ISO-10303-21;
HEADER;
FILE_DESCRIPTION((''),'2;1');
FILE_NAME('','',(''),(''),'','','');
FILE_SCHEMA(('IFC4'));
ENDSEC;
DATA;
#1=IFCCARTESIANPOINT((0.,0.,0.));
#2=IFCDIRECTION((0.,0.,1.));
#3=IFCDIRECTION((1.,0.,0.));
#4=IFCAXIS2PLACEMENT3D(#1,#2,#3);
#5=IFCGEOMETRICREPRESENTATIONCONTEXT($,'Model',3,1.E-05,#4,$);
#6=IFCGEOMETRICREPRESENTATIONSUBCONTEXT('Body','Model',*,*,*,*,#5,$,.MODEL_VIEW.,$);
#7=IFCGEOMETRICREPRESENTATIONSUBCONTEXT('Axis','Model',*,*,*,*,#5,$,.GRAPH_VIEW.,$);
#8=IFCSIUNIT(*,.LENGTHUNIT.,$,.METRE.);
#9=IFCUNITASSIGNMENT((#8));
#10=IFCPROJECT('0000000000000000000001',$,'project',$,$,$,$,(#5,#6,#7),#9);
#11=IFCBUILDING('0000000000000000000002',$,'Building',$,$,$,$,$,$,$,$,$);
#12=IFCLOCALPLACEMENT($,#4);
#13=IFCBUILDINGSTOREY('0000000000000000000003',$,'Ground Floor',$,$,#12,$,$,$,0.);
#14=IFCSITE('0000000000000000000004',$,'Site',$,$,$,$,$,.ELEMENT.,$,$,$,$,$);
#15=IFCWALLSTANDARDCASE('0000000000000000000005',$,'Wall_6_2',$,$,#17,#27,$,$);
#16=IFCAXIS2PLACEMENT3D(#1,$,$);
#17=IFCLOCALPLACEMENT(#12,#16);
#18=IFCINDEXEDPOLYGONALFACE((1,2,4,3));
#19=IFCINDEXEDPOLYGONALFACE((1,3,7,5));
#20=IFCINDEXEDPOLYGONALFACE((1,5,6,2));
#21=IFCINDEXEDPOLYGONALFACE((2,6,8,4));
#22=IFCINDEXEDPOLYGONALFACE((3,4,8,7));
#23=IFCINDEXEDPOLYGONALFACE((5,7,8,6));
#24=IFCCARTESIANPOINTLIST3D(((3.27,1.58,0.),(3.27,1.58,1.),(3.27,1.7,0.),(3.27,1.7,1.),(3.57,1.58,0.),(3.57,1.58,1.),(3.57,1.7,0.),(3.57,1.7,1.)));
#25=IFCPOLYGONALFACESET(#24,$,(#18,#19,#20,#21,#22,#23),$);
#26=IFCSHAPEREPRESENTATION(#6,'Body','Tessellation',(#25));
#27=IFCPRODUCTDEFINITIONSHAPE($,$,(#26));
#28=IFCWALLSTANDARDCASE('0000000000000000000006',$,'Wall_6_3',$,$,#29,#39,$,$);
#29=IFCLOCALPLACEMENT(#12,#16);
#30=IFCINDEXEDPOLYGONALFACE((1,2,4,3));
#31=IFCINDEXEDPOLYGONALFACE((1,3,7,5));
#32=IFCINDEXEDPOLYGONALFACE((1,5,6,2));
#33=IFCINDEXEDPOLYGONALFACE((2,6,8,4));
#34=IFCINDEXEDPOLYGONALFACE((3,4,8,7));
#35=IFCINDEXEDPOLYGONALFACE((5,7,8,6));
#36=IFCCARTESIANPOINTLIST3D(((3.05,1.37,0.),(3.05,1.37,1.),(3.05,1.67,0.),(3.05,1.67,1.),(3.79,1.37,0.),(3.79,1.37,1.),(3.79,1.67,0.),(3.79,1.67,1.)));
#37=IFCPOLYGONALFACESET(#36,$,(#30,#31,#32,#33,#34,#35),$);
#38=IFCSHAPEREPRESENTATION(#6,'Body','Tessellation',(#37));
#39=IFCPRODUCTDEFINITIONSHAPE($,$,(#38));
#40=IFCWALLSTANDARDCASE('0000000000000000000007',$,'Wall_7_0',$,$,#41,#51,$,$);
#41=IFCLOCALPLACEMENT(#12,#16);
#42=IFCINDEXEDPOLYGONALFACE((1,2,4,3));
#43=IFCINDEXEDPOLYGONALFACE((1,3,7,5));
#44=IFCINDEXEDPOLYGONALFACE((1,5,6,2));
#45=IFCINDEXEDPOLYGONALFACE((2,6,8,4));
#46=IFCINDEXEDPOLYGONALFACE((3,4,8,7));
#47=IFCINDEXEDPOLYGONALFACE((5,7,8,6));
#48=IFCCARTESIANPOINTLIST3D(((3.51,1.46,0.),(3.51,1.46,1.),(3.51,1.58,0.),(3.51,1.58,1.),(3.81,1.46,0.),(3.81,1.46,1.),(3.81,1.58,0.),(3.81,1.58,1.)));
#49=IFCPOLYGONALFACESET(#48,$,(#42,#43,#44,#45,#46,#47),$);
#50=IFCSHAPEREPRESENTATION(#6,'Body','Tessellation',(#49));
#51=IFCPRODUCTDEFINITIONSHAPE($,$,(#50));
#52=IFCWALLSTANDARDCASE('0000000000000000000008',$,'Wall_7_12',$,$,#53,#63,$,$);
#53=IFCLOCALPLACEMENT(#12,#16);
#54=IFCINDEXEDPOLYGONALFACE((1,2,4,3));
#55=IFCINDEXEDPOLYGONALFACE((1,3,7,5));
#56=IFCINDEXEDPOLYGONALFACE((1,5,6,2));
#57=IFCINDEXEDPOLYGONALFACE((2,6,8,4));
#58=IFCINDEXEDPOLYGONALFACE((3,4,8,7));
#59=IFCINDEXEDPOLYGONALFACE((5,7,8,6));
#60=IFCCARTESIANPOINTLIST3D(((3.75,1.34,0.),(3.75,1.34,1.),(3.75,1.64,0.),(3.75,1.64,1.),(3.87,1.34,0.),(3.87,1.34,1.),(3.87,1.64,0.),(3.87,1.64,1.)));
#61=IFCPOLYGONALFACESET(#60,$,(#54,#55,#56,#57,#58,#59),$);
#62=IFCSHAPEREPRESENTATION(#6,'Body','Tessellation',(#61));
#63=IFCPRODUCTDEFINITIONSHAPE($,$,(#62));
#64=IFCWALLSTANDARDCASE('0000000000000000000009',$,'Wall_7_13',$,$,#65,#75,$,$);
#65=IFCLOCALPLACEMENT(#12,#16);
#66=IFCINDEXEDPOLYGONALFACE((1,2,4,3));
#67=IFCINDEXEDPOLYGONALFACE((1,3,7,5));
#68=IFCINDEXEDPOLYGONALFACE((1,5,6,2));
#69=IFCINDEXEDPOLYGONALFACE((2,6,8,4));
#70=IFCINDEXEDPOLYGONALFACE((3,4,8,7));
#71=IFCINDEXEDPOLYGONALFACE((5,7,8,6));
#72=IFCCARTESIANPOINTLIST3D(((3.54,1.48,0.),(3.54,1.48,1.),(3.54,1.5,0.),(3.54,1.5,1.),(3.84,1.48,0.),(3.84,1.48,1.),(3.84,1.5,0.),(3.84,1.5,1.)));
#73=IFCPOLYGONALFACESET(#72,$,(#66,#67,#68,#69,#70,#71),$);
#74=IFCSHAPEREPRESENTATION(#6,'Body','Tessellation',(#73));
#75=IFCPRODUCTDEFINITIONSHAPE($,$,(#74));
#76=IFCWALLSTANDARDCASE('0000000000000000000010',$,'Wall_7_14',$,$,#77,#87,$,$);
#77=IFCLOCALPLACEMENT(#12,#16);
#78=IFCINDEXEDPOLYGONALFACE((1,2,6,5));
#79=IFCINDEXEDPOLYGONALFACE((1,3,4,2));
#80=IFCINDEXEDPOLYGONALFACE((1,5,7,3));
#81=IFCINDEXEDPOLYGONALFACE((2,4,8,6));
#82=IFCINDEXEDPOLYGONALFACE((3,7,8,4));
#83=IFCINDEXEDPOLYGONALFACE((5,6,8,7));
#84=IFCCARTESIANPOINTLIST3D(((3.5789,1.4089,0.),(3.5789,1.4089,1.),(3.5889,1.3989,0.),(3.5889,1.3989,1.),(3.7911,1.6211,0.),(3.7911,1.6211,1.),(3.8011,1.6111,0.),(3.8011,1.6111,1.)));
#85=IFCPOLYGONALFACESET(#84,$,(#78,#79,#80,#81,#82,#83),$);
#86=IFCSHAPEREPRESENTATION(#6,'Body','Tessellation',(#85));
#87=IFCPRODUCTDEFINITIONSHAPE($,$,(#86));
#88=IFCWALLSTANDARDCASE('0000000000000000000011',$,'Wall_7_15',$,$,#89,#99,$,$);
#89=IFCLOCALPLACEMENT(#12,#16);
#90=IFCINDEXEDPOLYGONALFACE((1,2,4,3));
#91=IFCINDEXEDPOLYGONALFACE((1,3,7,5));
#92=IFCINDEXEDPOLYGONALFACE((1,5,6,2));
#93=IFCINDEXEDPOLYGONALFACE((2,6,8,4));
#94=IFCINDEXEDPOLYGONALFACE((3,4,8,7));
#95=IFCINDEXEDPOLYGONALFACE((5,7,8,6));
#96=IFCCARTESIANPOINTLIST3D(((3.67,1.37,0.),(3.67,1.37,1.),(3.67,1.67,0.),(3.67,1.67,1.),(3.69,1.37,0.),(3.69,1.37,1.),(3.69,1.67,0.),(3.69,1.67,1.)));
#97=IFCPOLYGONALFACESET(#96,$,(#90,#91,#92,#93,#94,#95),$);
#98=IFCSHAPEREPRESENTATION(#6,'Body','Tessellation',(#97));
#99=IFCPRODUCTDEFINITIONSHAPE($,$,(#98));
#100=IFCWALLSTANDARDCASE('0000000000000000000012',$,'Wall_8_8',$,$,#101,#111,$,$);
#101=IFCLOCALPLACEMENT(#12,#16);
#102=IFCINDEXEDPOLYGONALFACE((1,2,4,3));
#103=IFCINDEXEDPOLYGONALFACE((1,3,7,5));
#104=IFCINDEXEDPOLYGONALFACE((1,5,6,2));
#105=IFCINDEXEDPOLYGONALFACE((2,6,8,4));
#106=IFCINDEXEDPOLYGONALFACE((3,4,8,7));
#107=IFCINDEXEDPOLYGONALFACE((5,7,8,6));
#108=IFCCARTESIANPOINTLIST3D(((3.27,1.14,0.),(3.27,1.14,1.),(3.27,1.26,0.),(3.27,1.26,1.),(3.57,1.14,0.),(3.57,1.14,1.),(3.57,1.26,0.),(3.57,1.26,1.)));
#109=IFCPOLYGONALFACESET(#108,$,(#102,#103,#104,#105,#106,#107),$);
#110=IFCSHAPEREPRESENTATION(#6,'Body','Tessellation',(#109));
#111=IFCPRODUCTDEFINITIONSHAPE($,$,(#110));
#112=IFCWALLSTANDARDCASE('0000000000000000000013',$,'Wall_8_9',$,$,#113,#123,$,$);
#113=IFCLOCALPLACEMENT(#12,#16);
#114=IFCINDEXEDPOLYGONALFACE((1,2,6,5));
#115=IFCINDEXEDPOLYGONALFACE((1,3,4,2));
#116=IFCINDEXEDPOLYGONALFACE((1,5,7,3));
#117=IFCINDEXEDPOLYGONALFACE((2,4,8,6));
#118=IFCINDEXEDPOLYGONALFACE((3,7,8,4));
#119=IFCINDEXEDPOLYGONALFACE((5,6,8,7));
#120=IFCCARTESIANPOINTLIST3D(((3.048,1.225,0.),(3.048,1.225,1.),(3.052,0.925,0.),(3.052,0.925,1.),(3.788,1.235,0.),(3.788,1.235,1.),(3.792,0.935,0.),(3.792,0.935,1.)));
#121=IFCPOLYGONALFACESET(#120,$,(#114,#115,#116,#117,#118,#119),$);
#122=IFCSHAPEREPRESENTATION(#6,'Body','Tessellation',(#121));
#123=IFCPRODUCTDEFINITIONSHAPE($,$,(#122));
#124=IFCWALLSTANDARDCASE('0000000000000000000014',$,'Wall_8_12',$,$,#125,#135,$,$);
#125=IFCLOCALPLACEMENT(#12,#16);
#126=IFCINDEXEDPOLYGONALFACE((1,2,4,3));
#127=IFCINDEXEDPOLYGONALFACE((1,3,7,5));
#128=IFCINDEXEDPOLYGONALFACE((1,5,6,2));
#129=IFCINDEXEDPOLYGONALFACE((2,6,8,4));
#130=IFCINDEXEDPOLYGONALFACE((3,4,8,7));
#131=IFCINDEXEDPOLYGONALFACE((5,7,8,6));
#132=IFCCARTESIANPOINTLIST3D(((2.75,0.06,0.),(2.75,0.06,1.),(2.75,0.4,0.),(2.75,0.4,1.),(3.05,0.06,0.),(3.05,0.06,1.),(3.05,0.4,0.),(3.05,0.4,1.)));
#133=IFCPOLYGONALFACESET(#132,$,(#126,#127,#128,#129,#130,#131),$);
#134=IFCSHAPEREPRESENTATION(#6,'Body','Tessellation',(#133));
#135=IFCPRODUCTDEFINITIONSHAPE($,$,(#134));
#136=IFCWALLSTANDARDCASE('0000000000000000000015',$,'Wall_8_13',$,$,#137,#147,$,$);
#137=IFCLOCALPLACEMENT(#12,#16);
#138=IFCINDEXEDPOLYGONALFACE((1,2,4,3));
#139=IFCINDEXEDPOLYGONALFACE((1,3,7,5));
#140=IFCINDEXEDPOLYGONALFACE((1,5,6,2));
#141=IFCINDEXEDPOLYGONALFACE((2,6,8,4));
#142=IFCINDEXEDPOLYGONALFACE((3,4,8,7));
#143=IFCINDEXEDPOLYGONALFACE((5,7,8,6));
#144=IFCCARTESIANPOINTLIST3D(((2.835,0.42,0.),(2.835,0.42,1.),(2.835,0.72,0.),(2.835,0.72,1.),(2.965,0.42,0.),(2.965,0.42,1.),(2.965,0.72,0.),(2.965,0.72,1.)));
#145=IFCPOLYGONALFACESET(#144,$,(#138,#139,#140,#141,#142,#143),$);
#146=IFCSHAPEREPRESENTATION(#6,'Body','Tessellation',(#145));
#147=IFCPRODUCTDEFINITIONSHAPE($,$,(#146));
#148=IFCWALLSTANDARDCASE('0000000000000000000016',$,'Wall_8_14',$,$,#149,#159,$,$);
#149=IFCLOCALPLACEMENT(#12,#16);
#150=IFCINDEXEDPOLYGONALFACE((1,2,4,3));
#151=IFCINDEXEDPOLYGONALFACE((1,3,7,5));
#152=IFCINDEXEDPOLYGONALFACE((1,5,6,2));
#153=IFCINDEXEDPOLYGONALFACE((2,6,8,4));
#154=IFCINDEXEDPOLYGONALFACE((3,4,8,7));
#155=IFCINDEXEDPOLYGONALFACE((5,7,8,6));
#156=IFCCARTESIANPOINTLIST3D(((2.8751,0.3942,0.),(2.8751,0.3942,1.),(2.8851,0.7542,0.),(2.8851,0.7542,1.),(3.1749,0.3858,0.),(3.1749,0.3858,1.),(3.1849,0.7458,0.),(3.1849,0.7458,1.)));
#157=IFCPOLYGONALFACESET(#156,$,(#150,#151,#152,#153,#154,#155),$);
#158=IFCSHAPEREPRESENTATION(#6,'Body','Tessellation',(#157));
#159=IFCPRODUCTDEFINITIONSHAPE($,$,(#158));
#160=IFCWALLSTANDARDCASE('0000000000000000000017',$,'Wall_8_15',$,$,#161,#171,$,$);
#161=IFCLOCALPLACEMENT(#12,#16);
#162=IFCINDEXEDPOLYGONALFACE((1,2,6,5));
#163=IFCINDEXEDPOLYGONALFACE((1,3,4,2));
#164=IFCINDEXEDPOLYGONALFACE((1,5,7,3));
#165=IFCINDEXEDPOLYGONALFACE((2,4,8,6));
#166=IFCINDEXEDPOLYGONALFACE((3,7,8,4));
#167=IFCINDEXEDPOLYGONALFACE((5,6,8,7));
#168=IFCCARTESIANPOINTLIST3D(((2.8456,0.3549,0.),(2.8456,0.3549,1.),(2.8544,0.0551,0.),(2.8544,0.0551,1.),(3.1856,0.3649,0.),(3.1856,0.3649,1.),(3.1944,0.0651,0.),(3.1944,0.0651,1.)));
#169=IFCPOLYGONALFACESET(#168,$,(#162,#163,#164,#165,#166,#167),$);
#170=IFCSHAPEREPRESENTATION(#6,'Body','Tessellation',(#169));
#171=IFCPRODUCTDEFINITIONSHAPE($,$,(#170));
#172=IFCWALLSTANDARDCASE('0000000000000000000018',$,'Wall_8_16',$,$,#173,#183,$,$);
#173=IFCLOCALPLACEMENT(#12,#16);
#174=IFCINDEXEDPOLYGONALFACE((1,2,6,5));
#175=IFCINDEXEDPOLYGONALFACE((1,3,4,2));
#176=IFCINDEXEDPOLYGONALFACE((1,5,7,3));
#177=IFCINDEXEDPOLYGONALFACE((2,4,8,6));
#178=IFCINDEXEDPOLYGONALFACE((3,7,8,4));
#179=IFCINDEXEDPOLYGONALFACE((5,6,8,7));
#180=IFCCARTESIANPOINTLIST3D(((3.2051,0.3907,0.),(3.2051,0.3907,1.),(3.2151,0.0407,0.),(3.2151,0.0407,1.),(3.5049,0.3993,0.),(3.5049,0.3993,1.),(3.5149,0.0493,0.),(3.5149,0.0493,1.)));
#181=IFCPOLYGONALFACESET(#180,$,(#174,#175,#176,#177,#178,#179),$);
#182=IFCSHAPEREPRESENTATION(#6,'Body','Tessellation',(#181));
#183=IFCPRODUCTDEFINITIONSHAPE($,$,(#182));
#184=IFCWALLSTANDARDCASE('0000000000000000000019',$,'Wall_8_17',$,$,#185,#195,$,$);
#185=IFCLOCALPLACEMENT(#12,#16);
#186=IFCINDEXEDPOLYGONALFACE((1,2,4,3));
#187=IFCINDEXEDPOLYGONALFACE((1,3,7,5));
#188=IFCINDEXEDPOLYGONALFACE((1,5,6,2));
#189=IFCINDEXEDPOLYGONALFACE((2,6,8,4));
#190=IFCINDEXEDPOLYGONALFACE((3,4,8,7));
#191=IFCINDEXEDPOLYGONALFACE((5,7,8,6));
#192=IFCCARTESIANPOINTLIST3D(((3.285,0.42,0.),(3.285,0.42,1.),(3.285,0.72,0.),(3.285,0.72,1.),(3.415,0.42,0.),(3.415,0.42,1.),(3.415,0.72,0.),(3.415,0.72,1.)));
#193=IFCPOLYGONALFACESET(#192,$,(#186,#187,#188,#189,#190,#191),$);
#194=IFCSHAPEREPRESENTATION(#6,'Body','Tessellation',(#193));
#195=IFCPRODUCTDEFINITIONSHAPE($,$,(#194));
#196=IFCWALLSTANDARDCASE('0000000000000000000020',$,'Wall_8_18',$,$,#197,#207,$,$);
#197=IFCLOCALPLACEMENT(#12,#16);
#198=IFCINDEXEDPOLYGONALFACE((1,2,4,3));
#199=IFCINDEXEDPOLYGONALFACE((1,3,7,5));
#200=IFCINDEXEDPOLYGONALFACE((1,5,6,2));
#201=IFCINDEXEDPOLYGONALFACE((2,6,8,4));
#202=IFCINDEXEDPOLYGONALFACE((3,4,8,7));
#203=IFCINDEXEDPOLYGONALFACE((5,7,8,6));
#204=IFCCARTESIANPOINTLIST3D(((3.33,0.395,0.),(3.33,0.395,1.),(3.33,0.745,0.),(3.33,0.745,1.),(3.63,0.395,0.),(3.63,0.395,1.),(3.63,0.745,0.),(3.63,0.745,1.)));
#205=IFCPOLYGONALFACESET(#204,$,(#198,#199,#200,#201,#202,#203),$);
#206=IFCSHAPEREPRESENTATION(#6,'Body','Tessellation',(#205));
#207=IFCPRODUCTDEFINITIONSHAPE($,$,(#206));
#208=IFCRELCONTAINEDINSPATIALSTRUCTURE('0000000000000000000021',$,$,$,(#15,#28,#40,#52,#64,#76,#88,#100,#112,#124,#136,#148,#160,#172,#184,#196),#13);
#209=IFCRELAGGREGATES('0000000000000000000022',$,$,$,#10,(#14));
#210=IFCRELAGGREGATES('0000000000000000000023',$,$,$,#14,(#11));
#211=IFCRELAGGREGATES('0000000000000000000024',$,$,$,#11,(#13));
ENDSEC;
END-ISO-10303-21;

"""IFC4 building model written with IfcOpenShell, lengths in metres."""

from ifc_helpers import new_model, si_unit, frame, origin_with_axes, origin_2d, place, context, subcontext, project, spatial, rectangle, extrude, element, save


model = new_model("IFC4")

# Units and contexts
model_context = context("Model", 3, precision=1e-05, world=origin_with_axes())
body_context = subcontext(model_context, "Body", "Model", "MODEL_VIEW")
axis_context = subcontext(model_context, "Axis", "Model", "GRAPH_VIEW")
ifc_project = project(units=[si_unit("LENGTHUNIT", "METRE")], contexts=[model_context, body_context, axis_context])

# Site, building, storey
site = spatial("IfcSite", under=ifc_project, Name="Site", CompositionType="ELEMENT")
building = spatial("IfcBuilding", under=site, Name="Building")
storey_placement = place(None, origin_with_axes())
storey = spatial("IfcBuildingStorey", under=building, at=storey_placement, Name="Ground Floor", Elevation=0.0)

# Walls
wall_1_placement = place(storey_placement, frame((3.42, 1.64, 0.0), z_axis=(0.0, 0.0, 1.0), x_axis=(0.0, -1.0, 0.0)))
element("IfcWallStandardCase", 1, at=wall_1_placement, inside=storey, Name="Wall_6_2", context=body_context, shape_type="SweptSolid", body=[
    extrude(rectangle(XDim=0.12, YDim=0.3, at=origin_2d()), origin_with_axes(), (0.0, 0.0, 1.0), 1.0),
])
wall_2_placement = place(storey_placement, frame((3.42, 1.52, 0.0), z_axis=(0.0, 0.0, 1.0), x_axis=(-1.0, 0.0, 0.0)))
element("IfcWallStandardCase", 2, at=wall_2_placement, inside=storey, Name="Wall_6_3", context=body_context, shape_type="SweptSolid", body=[
    extrude(rectangle(XDim=0.74, YDim=0.3, at=origin_2d()), origin_with_axes(), (0.0, 0.0, 1.0), 1.0),
])
for number, where, z_axis, x_axis, name in (
    (3, (3.66, 1.52, 0.0), (0.0, 0.0, 1.0), (0.0, 1.0, 0.0), "Wall_7_0"),
    (4, (3.81, 1.49, 0.0), (0.0, 0.0, 1.0), (-1.0, 0.0, 0.0), "Wall_7_12"),
):
    element("IfcWallStandardCase", number, at=place(storey_placement, frame(where, z_axis=z_axis, x_axis=x_axis)), inside=storey, Name=name, context=body_context, shape_type="SweptSolid", body=[
        extrude(rectangle(XDim=0.12, YDim=0.3, at=origin_2d()), origin_with_axes(), (0.0, 0.0, 1.0), 1.0),
    ])
wall_3_placement = place(storey_placement, frame((3.69, 1.49, 0.0), z_axis=(0.0, 0.0, 1.0), x_axis=(0.0, 1.0, 0.0)))
element("IfcWallStandardCase", 5, at=wall_3_placement, inside=storey, Name="Wall_7_13", context=body_context, shape_type="SweptSolid", body=[
    extrude(rectangle(XDim=0.02, YDim=0.3, at=origin_2d()), origin_with_axes(), (0.0, 0.0, 1.0), 1.0),
])
wall_4_placement = place(storey_placement, frame((3.69, 1.51, 0.0), z_axis=(0.0, 0.0, 1.0), x_axis=(-0.707107, 0.707107, 0.0)))
element("IfcWallStandardCase", 6, at=wall_4_placement, inside=storey, Name="Wall_7_14", context=body_context, shape_type="SweptSolid", body=[
    extrude(rectangle(XDim=0.0141, YDim=0.3, at=origin_2d()), origin_with_axes(), (0.0, 0.0, 1.0), 1.0),
])
wall_5_placement = place(storey_placement, frame((3.68, 1.52, 0.0), z_axis=(0.0, 0.0, 1.0), x_axis=(-1.0, 0.0, 0.0)))
element("IfcWallStandardCase", 7, at=wall_5_placement, inside=storey, Name="Wall_7_15", context=body_context, shape_type="SweptSolid", body=[
    extrude(rectangle(XDim=0.02, YDim=0.3, at=origin_2d()), origin_with_axes(), (0.0, 0.0, 1.0), 1.0),
])
wall_6_placement = place(storey_placement, frame((3.42, 1.2, 0.0), z_axis=(0.0, 0.0, 1.0), x_axis=(0.0, -1.0, 0.0)))
element("IfcWallStandardCase", 8, at=wall_6_placement, inside=storey, Name="Wall_8_8", context=body_context, shape_type="SweptSolid", body=[
    extrude(rectangle(XDim=0.12, YDim=0.3, at=origin_2d()), origin_with_axes(), (0.0, 0.0, 1.0), 1.0),
])
wall_7_placement = place(storey_placement, frame((3.42, 1.08, 0.0), z_axis=(0.0, 0.0, 1.0), x_axis=(-0.999909, -0.013512, 0.0)))
element("IfcWallStandardCase", 9, at=wall_7_placement, inside=storey, Name="Wall_8_9", context=body_context, shape_type="SweptSolid", body=[
    extrude(rectangle(XDim=0.7401, YDim=0.3, at=origin_2d()), origin_with_axes(), (0.0, 0.0, 1.0), 1.0),
])
wall_8_placement = place(storey_placement, frame((2.9, 0.23, 0.0), z_axis=(0.0, 0.0, 1.0), x_axis=(0.0, 1.0, 0.0)))
element("IfcWallStandardCase", 10, at=wall_8_placement, inside=storey, Name="Wall_8_12", context=body_context, shape_type="SweptSolid", body=[
    extrude(rectangle(XDim=0.34, YDim=0.3, at=origin_2d()), origin_with_axes(), (0.0, 0.0, 1.0), 1.0),
])
wall_9_placement = place(storey_placement, frame((2.9, 0.57, 0.0), z_axis=(0.0, 0.0, 1.0), x_axis=(1.0, 0.0, 0.0)))
element("IfcWallStandardCase", 11, at=wall_9_placement, inside=storey, Name="Wall_8_13", context=body_context, shape_type="SweptSolid", body=[
    extrude(rectangle(XDim=0.13, YDim=0.3, at=origin_2d()), origin_with_axes(), (0.0, 0.0, 1.0), 1.0),
])
wall_10_placement = place(storey_placement, frame((3.03, 0.57, 0.0), z_axis=(0.0, 0.0, 1.0), x_axis=(-0.027767, -0.999614, 0.0)))
element("IfcWallStandardCase", 12, at=wall_10_placement, inside=storey, Name="Wall_8_14", context=body_context, shape_type="SweptSolid", body=[
    extrude(rectangle(XDim=0.3601, YDim=0.3, at=origin_2d()), origin_with_axes(), (0.0, 0.0, 1.0), 1.0),
])
wall_11_placement = place(storey_placement, frame((3.02, 0.21, 0.0), z_axis=(0.0, 0.0, 1.0), x_axis=(0.999568, 0.029399, 0.0)))
element("IfcWallStandardCase", 13, at=wall_11_placement, inside=storey, Name="Wall_8_15", context=body_context, shape_type="SweptSolid", body=[
    extrude(rectangle(XDim=0.3401, YDim=0.3, at=origin_2d()), origin_with_axes(), (0.0, 0.0, 1.0), 1.0),
])
wall_12_placement = place(storey_placement, frame((3.36, 0.22, 0.0), z_axis=(0.0, 0.0, 1.0), x_axis=(-0.02856, 0.999592, 0.0)))
element("IfcWallStandardCase", 14, at=wall_12_placement, inside=storey, Name="Wall_8_16", context=body_context, shape_type="SweptSolid", body=[
    extrude(rectangle(XDim=0.3501, YDim=0.3, at=origin_2d()), origin_with_axes(), (0.0, 0.0, 1.0), 1.0),
])
wall_13_placement = place(storey_placement, frame((3.35, 0.57, 0.0), z_axis=(0.0, 0.0, 1.0), x_axis=(1.0, 0.0, 0.0)))
element("IfcWallStandardCase", 15, at=wall_13_placement, inside=storey, Name="Wall_8_17", context=body_context, shape_type="SweptSolid", body=[
    extrude(rectangle(XDim=0.13, YDim=0.3, at=origin_2d()), origin_with_axes(), (0.0, 0.0, 1.0), 1.0),
])
wall_14_placement = place(storey_placement, frame((3.48, 0.57, 0.0), z_axis=(0.0, 0.0, 1.0), x_axis=(0.0, -1.0, 0.0)))
element("IfcWallStandardCase", 16, at=wall_14_placement, inside=storey, Name="Wall_8_18", context=body_context, shape_type="SweptSolid", body=[
    extrude(rectangle(XDim=0.35, YDim=0.3, at=origin_2d()), origin_with_axes(), (0.0, 0.0, 1.0), 1.0),
])

save(model, "model.ifc")
